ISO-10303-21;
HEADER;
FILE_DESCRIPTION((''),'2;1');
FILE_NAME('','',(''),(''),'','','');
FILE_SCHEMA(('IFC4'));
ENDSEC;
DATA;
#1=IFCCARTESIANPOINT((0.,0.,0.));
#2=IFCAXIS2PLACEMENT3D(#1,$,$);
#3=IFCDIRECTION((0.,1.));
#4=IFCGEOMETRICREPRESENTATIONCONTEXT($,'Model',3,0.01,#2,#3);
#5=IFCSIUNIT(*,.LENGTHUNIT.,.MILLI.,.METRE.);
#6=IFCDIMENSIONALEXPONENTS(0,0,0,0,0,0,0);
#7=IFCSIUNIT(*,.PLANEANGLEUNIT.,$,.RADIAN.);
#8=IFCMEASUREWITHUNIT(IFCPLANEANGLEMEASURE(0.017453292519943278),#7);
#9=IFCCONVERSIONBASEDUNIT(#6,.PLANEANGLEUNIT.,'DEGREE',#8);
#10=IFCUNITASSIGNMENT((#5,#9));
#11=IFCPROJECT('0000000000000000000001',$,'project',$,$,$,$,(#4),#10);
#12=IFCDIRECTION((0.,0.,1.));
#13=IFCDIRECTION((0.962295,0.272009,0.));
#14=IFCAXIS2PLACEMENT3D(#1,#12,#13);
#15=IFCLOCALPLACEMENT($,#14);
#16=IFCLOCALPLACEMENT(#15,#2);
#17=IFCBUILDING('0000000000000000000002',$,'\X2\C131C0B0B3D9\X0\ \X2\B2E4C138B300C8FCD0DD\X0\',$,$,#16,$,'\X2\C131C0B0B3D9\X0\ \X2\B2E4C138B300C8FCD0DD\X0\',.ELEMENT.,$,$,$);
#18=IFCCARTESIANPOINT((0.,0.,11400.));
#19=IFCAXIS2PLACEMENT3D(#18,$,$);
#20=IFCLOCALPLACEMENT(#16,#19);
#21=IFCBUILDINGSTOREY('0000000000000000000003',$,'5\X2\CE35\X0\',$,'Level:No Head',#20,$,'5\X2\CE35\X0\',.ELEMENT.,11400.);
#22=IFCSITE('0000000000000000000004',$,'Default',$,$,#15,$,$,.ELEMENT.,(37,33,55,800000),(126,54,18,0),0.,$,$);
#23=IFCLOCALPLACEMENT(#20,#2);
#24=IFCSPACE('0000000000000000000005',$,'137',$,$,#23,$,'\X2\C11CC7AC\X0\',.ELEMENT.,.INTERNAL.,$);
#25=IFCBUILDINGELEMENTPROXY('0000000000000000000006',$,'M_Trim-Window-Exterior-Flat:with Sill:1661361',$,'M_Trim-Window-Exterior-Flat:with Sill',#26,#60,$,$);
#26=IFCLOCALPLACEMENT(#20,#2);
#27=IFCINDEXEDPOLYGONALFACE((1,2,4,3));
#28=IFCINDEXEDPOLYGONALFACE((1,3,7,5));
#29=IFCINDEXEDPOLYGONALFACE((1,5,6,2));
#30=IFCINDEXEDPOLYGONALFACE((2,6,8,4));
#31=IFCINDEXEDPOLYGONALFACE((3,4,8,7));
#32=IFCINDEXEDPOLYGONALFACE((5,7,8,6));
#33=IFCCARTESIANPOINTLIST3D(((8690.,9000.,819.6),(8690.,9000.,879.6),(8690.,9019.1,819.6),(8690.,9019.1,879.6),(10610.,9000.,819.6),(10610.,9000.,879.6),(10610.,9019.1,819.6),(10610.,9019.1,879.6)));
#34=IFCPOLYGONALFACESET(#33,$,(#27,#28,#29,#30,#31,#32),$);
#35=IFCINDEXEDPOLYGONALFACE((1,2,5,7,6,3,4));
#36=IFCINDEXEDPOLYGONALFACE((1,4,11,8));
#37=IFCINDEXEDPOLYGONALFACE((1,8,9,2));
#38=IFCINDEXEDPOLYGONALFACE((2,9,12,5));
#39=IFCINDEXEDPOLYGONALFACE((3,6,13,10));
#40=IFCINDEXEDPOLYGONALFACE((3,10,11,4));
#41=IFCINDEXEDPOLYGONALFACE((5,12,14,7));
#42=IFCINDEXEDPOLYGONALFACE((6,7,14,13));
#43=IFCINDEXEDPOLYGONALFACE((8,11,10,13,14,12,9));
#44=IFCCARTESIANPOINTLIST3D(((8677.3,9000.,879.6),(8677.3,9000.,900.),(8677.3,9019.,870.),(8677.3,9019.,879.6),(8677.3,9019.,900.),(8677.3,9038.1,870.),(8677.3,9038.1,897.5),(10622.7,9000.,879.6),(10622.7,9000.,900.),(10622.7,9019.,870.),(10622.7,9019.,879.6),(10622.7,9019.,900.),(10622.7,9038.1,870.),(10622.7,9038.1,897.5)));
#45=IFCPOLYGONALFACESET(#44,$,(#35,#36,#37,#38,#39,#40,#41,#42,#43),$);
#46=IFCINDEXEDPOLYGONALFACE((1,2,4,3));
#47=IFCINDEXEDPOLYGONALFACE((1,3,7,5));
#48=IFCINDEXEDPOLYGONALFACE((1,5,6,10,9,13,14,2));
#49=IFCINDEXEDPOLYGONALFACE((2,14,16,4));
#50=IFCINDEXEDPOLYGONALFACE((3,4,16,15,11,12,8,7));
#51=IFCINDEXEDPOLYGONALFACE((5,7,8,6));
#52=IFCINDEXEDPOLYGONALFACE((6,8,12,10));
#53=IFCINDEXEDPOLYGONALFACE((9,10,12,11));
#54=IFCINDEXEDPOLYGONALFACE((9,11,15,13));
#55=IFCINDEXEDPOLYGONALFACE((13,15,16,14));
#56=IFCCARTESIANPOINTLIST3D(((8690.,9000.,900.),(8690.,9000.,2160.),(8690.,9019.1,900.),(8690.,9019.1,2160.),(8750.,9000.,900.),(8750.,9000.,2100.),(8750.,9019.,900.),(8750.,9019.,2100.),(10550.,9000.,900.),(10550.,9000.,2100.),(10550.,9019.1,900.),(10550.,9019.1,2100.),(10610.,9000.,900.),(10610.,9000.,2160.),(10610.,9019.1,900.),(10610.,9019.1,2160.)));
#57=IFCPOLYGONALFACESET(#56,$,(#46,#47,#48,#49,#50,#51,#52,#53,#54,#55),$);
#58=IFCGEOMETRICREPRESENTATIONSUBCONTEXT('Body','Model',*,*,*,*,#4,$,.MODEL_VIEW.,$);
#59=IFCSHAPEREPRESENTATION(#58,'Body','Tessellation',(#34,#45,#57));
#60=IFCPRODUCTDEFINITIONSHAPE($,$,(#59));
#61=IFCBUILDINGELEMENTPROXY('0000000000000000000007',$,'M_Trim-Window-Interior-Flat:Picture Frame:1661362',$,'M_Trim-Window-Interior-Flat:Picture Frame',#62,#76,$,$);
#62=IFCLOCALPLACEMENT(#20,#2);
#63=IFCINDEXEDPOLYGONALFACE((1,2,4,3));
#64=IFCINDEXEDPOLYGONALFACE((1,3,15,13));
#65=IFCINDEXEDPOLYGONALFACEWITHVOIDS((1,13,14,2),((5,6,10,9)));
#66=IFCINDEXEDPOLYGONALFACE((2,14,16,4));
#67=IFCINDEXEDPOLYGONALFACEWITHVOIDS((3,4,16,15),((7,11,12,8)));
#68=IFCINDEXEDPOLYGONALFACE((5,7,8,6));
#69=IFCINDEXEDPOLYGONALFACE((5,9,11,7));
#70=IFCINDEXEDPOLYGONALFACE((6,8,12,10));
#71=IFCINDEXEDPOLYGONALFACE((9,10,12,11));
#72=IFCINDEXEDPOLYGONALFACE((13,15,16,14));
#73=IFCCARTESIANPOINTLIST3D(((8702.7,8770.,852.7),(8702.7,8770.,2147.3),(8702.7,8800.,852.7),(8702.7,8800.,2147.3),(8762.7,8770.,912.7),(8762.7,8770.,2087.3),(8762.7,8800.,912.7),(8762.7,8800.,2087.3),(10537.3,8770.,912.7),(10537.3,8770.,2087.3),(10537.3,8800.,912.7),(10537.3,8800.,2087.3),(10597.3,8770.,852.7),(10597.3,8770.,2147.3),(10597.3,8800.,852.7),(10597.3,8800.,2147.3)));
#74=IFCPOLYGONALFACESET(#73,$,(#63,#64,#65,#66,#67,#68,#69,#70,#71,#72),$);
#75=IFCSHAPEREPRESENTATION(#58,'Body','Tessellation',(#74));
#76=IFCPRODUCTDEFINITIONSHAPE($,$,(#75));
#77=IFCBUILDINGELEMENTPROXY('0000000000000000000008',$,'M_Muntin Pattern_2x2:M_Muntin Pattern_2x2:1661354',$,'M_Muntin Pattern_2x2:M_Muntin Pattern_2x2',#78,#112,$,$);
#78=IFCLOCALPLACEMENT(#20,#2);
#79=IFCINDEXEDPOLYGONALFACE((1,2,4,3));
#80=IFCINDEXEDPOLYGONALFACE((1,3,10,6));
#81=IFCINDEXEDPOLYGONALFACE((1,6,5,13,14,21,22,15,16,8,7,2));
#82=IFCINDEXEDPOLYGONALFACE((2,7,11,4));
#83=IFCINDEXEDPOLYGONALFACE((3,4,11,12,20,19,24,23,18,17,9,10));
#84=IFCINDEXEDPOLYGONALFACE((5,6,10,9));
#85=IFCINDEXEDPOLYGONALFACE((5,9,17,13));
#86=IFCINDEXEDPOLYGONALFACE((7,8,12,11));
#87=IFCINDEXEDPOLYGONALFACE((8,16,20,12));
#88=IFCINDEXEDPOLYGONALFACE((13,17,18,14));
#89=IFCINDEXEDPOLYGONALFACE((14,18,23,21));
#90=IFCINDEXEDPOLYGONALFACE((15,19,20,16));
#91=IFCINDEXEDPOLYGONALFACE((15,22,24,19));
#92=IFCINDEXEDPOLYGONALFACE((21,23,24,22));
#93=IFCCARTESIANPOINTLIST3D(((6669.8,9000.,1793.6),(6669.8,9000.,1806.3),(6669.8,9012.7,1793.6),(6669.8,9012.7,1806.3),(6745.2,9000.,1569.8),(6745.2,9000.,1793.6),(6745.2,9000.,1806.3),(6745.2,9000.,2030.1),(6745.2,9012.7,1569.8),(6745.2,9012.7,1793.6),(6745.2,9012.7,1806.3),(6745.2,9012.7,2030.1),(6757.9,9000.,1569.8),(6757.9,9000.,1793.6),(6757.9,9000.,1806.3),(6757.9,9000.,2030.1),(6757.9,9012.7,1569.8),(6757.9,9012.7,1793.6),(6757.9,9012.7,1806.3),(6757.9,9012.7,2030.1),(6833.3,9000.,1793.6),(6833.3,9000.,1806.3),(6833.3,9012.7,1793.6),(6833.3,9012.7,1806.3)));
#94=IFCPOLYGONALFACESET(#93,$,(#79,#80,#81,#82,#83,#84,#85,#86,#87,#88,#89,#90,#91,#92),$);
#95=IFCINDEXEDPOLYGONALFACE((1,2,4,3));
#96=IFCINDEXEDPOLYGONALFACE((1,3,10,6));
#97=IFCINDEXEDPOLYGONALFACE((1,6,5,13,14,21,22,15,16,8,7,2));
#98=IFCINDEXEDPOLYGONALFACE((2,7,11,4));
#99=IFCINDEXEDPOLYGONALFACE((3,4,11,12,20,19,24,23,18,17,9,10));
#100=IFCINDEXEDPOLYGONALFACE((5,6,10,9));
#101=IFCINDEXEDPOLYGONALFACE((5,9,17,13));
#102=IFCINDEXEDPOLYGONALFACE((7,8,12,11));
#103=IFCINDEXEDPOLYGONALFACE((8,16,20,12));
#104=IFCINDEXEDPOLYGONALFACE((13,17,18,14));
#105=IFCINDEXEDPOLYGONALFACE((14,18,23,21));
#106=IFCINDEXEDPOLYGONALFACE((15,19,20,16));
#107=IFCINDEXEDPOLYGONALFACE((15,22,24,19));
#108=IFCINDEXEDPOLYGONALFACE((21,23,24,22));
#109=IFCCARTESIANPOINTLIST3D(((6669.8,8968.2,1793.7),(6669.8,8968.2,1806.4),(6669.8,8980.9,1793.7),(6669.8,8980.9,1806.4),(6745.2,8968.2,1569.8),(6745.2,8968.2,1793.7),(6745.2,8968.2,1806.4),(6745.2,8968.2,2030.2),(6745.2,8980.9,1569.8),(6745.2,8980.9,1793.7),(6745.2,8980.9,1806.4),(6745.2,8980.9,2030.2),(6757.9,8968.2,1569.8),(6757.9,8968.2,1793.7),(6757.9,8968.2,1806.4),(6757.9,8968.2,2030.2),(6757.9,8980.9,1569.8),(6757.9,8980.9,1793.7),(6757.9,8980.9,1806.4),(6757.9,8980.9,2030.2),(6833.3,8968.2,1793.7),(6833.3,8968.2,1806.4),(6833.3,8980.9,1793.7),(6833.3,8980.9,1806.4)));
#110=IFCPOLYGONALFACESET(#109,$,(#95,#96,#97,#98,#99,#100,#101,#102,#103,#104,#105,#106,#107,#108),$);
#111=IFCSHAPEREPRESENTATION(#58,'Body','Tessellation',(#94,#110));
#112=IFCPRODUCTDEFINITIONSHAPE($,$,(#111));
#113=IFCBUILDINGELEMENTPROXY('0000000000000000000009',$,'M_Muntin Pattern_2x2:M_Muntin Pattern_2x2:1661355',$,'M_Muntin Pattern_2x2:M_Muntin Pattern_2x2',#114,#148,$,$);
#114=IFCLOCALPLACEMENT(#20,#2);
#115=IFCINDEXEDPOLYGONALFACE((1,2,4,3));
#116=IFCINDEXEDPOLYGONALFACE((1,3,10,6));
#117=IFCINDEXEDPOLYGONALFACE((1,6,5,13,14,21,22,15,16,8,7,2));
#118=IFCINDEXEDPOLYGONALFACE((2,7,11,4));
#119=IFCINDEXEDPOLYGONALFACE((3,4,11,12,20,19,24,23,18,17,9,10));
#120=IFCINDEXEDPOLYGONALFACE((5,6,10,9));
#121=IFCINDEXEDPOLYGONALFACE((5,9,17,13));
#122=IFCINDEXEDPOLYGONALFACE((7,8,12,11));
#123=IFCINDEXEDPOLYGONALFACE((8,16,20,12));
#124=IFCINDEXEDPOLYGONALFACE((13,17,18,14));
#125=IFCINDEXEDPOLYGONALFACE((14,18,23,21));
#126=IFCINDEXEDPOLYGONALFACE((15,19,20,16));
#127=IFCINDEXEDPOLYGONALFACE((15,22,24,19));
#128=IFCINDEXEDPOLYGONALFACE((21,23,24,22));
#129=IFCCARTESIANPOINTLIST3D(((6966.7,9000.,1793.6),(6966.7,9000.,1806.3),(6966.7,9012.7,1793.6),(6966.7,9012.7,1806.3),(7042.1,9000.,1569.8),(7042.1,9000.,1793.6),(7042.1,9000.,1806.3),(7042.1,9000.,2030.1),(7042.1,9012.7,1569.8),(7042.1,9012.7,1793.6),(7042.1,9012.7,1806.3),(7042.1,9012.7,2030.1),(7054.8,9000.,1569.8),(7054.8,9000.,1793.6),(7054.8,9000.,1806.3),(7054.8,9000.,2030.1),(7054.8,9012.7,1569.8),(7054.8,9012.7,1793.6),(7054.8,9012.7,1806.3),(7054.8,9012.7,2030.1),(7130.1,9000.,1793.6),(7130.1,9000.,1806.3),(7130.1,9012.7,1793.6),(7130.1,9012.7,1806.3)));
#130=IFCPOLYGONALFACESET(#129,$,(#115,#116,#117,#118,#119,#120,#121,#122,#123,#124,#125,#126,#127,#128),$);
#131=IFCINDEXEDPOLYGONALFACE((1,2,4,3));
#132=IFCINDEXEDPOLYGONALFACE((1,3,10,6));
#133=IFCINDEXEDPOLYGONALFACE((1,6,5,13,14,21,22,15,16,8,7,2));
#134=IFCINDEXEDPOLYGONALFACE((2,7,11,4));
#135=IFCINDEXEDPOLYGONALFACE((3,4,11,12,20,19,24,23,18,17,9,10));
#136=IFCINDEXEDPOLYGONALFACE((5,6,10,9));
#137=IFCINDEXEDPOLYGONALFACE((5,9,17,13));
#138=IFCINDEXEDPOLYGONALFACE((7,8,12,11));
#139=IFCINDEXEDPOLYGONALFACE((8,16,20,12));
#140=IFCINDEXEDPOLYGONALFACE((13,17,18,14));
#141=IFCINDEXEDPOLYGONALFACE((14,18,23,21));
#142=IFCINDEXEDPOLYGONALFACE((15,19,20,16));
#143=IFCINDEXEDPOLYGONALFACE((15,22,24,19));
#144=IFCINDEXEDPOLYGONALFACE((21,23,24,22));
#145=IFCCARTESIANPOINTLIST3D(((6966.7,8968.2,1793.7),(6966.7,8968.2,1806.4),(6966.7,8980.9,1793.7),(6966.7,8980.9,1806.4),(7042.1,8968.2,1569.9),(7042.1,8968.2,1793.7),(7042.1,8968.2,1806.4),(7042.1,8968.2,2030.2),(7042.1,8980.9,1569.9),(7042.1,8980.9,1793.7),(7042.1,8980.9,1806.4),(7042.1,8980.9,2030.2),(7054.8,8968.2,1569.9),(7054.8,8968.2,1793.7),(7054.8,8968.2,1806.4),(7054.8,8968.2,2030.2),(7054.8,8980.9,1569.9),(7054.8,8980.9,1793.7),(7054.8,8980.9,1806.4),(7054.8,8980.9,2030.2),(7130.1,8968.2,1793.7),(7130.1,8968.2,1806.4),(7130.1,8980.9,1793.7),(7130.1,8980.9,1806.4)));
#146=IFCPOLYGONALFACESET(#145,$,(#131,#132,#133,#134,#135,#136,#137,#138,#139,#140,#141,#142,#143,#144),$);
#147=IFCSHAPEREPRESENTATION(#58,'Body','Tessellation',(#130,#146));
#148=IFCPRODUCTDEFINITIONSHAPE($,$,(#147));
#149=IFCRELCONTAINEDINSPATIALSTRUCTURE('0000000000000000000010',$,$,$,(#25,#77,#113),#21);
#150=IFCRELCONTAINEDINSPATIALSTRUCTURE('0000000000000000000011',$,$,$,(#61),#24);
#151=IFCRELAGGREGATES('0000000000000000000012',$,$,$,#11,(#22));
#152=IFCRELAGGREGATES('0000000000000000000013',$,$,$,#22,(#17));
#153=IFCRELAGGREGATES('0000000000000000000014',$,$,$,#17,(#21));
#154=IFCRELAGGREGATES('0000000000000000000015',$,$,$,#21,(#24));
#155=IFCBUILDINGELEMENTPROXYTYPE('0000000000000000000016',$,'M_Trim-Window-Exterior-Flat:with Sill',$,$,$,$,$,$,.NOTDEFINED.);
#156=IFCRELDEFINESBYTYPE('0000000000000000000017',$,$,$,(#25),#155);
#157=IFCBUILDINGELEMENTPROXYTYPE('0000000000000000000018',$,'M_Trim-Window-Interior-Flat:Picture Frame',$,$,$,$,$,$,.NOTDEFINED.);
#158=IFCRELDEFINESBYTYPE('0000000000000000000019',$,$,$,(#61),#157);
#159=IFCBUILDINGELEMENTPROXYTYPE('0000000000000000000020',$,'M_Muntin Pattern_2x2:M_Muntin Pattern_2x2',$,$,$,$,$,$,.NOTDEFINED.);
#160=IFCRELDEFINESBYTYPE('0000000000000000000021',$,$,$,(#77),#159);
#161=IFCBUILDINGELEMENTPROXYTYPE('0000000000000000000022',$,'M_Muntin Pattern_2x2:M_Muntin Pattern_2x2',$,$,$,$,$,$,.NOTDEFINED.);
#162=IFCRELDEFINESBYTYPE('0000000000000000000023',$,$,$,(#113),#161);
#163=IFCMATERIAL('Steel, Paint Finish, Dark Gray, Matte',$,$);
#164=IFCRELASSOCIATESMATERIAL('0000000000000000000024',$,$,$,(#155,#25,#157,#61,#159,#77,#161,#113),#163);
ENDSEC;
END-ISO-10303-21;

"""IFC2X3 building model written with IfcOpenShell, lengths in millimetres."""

from ifc_helpers import new_model, entity, si_unit, converted_unit, direction, frame, frame_2d, origin, place, context, subcontext, project, spatial, polyline, rectangle, outline, extrude, source, transform, mapped, material, type_object, type_shapes, element, save


model = new_model("IFC2X3")

# Units and contexts
model_context = context("Model", 3, precision=0.01, world=origin(), true_north=direction((0.0, 1.0)))
body_context = subcontext(model_context, "Body", "Model", "MODEL_VIEW")
ifc_project = project(units=[si_unit("LENGTHUNIT", "METRE", prefix="MILLI"), converted_unit("PLANEANGLEUNIT", "DEGREE", entity("IfcPlaneAngleMeasure", 0.017453292519943278), si_unit("PLANEANGLEUNIT", "RADIAN"), dimensions=[0, 0, 0, 0, 0, 0, 0])], contexts=[model_context])

# Site, building, storey
site_placement = place(None, frame((0.0, 0.0, 0.0), z_axis=(0.0, 0.0, 1.0), x_axis=(0.962295, 0.272009, 0.0)))
site = spatial("IfcSite", under=ifc_project, at=site_placement, Name="Default", CompositionType="ELEMENT", RefLatitude=(37, 33, 55, 800000), RefLongitude=(126, 54, 18, 0), RefElevation=0.0)
building_placement = place(site_placement, origin())
building = spatial("IfcBuilding", under=site, at=building_placement, Name="성산동 다세대주택", LongName="성산동 다세대주택", CompositionType="ELEMENT")
storey_placement = place(building_placement, frame((0.0, 0.0, 11400.0)))
storey = spatial("IfcBuildingStorey", under=building, at=storey_placement, Name="5층", ObjectType="Level:No Head", LongName="5층", CompositionType="ELEMENT", Elevation=11400.0)

# Shared definitions
space_1_placement = place(storey_placement, origin())
space_1 = spatial("IfcSpace", under=storey, at=space_1_placement, Name="137", LongName="서재", CompositionType="ELEMENT", InteriorOrExteriorSpace="INTERNAL")

# Building element proxies
ifc_material_1 = material(Name="Steel, Paint Finish, Dark Gray, Matte")
building_element_proxy_type_1 = type_object("IfcBuildingElementProxyType", Name="M_Trim-Window-Exterior-Flat:with Sill", PredefinedType="NOTDEFINED", material=ifc_material_1)
shared_shape_1 = source(origin(), body_context, "Body", "SweptSolid", [
    extrude(rectangle(XDim=1920.0, YDim=60.0, at=frame_2d((0.0, 0.0), x_axis=(1.0, 0.0))), frame((0.0, -1250.4, 0.0), z_axis=(0.0, 0.0, 1.0), x_axis=(-1.0, 0.0, 0.0)), (0.0, 0.0, 1.0), 19.0),
    extrude(outline(polyline([(-19.0, -15.2), (0.0, -15.2), (0.0, -5.7), (19.0, -5.7), (19.0, 14.8), (0.0, 14.8), (-19.0, 12.3), (-19.0, -15.2)])), frame((-972.7, -1214.8, 19.0), z_axis=(1.0, 0.0, 0.0), x_axis=(0.0, 0.0, -1.0)), (0.0, 0.0, 1.0), 1945.4),
    extrude(outline(polyline([(-645.0, -960.0), (615.0, -960.0), (615.0, -900.0), (-585.0, -900.0), (-585.0, 900.0), (615.0, 900.0), (615.0, 960.0), (-645.0, 960.0), (-645.0, -960.0)])), frame((0.0, -585.0, 0.0), z_axis=(0.0, 0.0, 1.0), x_axis=(0.0, -1.0, 0.0)), (0.0, 0.0, 1.0), 19.0),
])
type_shapes(building_element_proxy_type_1, [shared_shape_1])
proxy_1_placement = place(storey_placement, frame((9650.0, 9000.0, 2100.0), z_axis=(0.0, 1.0, 0.0), x_axis=(-1.0, 0.0, 0.0)))
element("IfcBuildingElementProxy", 1, at=proxy_1_placement, inside=storey, type_object=building_element_proxy_type_1, material=ifc_material_1, Name="M_Trim-Window-Exterior-Flat:with Sill:1661361", ObjectType="M_Trim-Window-Exterior-Flat:with Sill", context=body_context, shape_type="MappedRepresentation", body=[
    mapped(shared_shape_1, transform((0.0, 0.0, 0.0), scale=1.0)),
])
building_element_proxy_type_2 = type_object("IfcBuildingElementProxyType", Name="M_Trim-Window-Interior-Flat:Picture Frame", PredefinedType="NOTDEFINED", material=ifc_material_1)
shared_shape_2 = source(origin(), body_context, "Body", "SweptSolid", [
    extrude(outline(polyline([(-947.3, -647.3), (947.3, -647.3), (947.3, 647.3), (-947.3, 647.3), (-947.3, -647.3)]), holes=[polyline([(-887.3, -587.3), (-887.3, 587.3), (887.3, 587.3), (887.3, -587.3), (-887.3, -587.3)])]), frame((0.0, -600.0, 0.0), z_axis=(0.0, 0.0, 1.0), x_axis=(-1.0, 0.0, 0.0)), (0.0, 0.0, 1.0), 30.0),
])
type_shapes(building_element_proxy_type_2, [shared_shape_2])
proxy_2_placement = place(space_1_placement, frame((9650.0, 8800.0, 2100.0), z_axis=(0.0, -1.0, 0.0), x_axis=(1.0, 0.0, 0.0)))
element("IfcBuildingElementProxy", 2, at=proxy_2_placement, inside=space_1, type_object=building_element_proxy_type_2, material=ifc_material_1, Name="M_Trim-Window-Interior-Flat:Picture Frame:1661362", ObjectType="M_Trim-Window-Interior-Flat:Picture Frame", context=body_context, shape_type="MappedRepresentation", body=[
    mapped(shared_shape_2, transform((0.0, 0.0, 0.0), scale=1.0)),
])
building_element_proxy_type_3 = type_object("IfcBuildingElementProxyType", Name="M_Muntin Pattern_2x2:M_Muntin Pattern_2x2", PredefinedType="NOTDEFINED", material=ifc_material_1)
shared_shape_3 = source(origin(), body_context, "Body", "SweptSolid", [
    extrude(outline(polyline([(6.4, -6.4), (230.1, -6.4), (230.1, 6.3), (6.4, 6.3), (6.4, 81.7), (-6.3, 81.7), (-6.3, 6.3), (-230.2, 6.3), (-230.2, -6.4), (-6.3, -6.4), (-6.3, -81.7), (6.4, -81.7), (6.4, -6.4)])), frame((0.0, 9.5, 230.1), z_axis=(0.0, 1.0, 0.0), x_axis=(0.0, 0.0, 1.0)), (0.0, 0.0, 1.0), 12.7),
    extrude(outline(polyline([(6.4, -6.4), (230.2, -6.4), (230.2, 6.3), (6.4, 6.3), (6.4, 81.7), (-6.3, 81.7), (-6.3, 6.3), (-230.2, 6.3), (-230.2, -6.4), (-6.3, -6.4), (-6.3, -81.7), (6.4, -81.7), (6.4, -6.4)])), frame((0.0, -22.2, 230.2), z_axis=(0.0, 1.0, 0.0), x_axis=(0.0, 0.0, 1.0)), (0.0, 0.0, 1.0), 12.7),
])
type_shapes(building_element_proxy_type_3, [shared_shape_3])
proxy_3_placement = place(storey_placement, frame((6751.6, 8990.5, 1569.8)))
element("IfcBuildingElementProxy", 3, at=proxy_3_placement, inside=storey, type_object=building_element_proxy_type_3, material=ifc_material_1, Name="M_Muntin Pattern_2x2:M_Muntin Pattern_2x2:1661354", ObjectType="M_Muntin Pattern_2x2:M_Muntin Pattern_2x2", context=body_context, shape_type="MappedRepresentation", body=[
    mapped(shared_shape_3, transform((0.0, 0.0, 0.0), scale=1.0)),
])
building_element_proxy_type_4 = type_object("IfcBuildingElementProxyType", Name="M_Muntin Pattern_2x2:M_Muntin Pattern_2x2", PredefinedType="NOTDEFINED", material=ifc_material_1)
shared_shape_4 = source(origin(), body_context, "Body", "SweptSolid", [
    extrude(outline(polyline([(6.4, -6.4), (230.1, -6.4), (230.1, 6.3), (6.4, 6.3), (6.4, 81.7), (-6.3, 81.7), (-6.3, 6.3), (-230.2, 6.3), (-230.2, -6.4), (-6.3, -6.4), (-6.3, -81.7), (6.4, -81.7), (6.4, -6.4)])), frame((0.0, -22.2, 230.1), z_axis=(0.0, 1.0, 0.0), x_axis=(0.0, 0.0, 1.0)), (0.0, 0.0, 1.0), 12.7),
    extrude(outline(polyline([(6.4, -6.4), (230.2, -6.4), (230.2, 6.3), (6.4, 6.3), (6.4, 81.7), (-6.3, 81.7), (-6.3, 6.3), (-230.2, 6.3), (-230.2, -6.4), (-6.3, -6.4), (-6.3, -81.7), (6.4, -81.7), (6.4, -6.4)])), frame((0.0, 9.5, 230.2), z_axis=(0.0, 1.0, 0.0), x_axis=(0.0, 0.0, 1.0)), (0.0, 0.0, 1.0), 12.7),
])
type_shapes(building_element_proxy_type_4, [shared_shape_4])
proxy_4_placement = place(storey_placement, frame((7048.4, 8990.5, 1569.9), z_axis=(0.0, 0.0, 1.0), x_axis=(-1.0, 0.0, 0.0)))
element("IfcBuildingElementProxy", 4, at=proxy_4_placement, inside=storey, type_object=building_element_proxy_type_4, material=ifc_material_1, Name="M_Muntin Pattern_2x2:M_Muntin Pattern_2x2:1661355", ObjectType="M_Muntin Pattern_2x2:M_Muntin Pattern_2x2", context=body_context, shape_type="MappedRepresentation", body=[
    mapped(shared_shape_4, transform((0.0, 0.0, 0.0), scale=1.0)),
])

save(model, "model.ifc")
